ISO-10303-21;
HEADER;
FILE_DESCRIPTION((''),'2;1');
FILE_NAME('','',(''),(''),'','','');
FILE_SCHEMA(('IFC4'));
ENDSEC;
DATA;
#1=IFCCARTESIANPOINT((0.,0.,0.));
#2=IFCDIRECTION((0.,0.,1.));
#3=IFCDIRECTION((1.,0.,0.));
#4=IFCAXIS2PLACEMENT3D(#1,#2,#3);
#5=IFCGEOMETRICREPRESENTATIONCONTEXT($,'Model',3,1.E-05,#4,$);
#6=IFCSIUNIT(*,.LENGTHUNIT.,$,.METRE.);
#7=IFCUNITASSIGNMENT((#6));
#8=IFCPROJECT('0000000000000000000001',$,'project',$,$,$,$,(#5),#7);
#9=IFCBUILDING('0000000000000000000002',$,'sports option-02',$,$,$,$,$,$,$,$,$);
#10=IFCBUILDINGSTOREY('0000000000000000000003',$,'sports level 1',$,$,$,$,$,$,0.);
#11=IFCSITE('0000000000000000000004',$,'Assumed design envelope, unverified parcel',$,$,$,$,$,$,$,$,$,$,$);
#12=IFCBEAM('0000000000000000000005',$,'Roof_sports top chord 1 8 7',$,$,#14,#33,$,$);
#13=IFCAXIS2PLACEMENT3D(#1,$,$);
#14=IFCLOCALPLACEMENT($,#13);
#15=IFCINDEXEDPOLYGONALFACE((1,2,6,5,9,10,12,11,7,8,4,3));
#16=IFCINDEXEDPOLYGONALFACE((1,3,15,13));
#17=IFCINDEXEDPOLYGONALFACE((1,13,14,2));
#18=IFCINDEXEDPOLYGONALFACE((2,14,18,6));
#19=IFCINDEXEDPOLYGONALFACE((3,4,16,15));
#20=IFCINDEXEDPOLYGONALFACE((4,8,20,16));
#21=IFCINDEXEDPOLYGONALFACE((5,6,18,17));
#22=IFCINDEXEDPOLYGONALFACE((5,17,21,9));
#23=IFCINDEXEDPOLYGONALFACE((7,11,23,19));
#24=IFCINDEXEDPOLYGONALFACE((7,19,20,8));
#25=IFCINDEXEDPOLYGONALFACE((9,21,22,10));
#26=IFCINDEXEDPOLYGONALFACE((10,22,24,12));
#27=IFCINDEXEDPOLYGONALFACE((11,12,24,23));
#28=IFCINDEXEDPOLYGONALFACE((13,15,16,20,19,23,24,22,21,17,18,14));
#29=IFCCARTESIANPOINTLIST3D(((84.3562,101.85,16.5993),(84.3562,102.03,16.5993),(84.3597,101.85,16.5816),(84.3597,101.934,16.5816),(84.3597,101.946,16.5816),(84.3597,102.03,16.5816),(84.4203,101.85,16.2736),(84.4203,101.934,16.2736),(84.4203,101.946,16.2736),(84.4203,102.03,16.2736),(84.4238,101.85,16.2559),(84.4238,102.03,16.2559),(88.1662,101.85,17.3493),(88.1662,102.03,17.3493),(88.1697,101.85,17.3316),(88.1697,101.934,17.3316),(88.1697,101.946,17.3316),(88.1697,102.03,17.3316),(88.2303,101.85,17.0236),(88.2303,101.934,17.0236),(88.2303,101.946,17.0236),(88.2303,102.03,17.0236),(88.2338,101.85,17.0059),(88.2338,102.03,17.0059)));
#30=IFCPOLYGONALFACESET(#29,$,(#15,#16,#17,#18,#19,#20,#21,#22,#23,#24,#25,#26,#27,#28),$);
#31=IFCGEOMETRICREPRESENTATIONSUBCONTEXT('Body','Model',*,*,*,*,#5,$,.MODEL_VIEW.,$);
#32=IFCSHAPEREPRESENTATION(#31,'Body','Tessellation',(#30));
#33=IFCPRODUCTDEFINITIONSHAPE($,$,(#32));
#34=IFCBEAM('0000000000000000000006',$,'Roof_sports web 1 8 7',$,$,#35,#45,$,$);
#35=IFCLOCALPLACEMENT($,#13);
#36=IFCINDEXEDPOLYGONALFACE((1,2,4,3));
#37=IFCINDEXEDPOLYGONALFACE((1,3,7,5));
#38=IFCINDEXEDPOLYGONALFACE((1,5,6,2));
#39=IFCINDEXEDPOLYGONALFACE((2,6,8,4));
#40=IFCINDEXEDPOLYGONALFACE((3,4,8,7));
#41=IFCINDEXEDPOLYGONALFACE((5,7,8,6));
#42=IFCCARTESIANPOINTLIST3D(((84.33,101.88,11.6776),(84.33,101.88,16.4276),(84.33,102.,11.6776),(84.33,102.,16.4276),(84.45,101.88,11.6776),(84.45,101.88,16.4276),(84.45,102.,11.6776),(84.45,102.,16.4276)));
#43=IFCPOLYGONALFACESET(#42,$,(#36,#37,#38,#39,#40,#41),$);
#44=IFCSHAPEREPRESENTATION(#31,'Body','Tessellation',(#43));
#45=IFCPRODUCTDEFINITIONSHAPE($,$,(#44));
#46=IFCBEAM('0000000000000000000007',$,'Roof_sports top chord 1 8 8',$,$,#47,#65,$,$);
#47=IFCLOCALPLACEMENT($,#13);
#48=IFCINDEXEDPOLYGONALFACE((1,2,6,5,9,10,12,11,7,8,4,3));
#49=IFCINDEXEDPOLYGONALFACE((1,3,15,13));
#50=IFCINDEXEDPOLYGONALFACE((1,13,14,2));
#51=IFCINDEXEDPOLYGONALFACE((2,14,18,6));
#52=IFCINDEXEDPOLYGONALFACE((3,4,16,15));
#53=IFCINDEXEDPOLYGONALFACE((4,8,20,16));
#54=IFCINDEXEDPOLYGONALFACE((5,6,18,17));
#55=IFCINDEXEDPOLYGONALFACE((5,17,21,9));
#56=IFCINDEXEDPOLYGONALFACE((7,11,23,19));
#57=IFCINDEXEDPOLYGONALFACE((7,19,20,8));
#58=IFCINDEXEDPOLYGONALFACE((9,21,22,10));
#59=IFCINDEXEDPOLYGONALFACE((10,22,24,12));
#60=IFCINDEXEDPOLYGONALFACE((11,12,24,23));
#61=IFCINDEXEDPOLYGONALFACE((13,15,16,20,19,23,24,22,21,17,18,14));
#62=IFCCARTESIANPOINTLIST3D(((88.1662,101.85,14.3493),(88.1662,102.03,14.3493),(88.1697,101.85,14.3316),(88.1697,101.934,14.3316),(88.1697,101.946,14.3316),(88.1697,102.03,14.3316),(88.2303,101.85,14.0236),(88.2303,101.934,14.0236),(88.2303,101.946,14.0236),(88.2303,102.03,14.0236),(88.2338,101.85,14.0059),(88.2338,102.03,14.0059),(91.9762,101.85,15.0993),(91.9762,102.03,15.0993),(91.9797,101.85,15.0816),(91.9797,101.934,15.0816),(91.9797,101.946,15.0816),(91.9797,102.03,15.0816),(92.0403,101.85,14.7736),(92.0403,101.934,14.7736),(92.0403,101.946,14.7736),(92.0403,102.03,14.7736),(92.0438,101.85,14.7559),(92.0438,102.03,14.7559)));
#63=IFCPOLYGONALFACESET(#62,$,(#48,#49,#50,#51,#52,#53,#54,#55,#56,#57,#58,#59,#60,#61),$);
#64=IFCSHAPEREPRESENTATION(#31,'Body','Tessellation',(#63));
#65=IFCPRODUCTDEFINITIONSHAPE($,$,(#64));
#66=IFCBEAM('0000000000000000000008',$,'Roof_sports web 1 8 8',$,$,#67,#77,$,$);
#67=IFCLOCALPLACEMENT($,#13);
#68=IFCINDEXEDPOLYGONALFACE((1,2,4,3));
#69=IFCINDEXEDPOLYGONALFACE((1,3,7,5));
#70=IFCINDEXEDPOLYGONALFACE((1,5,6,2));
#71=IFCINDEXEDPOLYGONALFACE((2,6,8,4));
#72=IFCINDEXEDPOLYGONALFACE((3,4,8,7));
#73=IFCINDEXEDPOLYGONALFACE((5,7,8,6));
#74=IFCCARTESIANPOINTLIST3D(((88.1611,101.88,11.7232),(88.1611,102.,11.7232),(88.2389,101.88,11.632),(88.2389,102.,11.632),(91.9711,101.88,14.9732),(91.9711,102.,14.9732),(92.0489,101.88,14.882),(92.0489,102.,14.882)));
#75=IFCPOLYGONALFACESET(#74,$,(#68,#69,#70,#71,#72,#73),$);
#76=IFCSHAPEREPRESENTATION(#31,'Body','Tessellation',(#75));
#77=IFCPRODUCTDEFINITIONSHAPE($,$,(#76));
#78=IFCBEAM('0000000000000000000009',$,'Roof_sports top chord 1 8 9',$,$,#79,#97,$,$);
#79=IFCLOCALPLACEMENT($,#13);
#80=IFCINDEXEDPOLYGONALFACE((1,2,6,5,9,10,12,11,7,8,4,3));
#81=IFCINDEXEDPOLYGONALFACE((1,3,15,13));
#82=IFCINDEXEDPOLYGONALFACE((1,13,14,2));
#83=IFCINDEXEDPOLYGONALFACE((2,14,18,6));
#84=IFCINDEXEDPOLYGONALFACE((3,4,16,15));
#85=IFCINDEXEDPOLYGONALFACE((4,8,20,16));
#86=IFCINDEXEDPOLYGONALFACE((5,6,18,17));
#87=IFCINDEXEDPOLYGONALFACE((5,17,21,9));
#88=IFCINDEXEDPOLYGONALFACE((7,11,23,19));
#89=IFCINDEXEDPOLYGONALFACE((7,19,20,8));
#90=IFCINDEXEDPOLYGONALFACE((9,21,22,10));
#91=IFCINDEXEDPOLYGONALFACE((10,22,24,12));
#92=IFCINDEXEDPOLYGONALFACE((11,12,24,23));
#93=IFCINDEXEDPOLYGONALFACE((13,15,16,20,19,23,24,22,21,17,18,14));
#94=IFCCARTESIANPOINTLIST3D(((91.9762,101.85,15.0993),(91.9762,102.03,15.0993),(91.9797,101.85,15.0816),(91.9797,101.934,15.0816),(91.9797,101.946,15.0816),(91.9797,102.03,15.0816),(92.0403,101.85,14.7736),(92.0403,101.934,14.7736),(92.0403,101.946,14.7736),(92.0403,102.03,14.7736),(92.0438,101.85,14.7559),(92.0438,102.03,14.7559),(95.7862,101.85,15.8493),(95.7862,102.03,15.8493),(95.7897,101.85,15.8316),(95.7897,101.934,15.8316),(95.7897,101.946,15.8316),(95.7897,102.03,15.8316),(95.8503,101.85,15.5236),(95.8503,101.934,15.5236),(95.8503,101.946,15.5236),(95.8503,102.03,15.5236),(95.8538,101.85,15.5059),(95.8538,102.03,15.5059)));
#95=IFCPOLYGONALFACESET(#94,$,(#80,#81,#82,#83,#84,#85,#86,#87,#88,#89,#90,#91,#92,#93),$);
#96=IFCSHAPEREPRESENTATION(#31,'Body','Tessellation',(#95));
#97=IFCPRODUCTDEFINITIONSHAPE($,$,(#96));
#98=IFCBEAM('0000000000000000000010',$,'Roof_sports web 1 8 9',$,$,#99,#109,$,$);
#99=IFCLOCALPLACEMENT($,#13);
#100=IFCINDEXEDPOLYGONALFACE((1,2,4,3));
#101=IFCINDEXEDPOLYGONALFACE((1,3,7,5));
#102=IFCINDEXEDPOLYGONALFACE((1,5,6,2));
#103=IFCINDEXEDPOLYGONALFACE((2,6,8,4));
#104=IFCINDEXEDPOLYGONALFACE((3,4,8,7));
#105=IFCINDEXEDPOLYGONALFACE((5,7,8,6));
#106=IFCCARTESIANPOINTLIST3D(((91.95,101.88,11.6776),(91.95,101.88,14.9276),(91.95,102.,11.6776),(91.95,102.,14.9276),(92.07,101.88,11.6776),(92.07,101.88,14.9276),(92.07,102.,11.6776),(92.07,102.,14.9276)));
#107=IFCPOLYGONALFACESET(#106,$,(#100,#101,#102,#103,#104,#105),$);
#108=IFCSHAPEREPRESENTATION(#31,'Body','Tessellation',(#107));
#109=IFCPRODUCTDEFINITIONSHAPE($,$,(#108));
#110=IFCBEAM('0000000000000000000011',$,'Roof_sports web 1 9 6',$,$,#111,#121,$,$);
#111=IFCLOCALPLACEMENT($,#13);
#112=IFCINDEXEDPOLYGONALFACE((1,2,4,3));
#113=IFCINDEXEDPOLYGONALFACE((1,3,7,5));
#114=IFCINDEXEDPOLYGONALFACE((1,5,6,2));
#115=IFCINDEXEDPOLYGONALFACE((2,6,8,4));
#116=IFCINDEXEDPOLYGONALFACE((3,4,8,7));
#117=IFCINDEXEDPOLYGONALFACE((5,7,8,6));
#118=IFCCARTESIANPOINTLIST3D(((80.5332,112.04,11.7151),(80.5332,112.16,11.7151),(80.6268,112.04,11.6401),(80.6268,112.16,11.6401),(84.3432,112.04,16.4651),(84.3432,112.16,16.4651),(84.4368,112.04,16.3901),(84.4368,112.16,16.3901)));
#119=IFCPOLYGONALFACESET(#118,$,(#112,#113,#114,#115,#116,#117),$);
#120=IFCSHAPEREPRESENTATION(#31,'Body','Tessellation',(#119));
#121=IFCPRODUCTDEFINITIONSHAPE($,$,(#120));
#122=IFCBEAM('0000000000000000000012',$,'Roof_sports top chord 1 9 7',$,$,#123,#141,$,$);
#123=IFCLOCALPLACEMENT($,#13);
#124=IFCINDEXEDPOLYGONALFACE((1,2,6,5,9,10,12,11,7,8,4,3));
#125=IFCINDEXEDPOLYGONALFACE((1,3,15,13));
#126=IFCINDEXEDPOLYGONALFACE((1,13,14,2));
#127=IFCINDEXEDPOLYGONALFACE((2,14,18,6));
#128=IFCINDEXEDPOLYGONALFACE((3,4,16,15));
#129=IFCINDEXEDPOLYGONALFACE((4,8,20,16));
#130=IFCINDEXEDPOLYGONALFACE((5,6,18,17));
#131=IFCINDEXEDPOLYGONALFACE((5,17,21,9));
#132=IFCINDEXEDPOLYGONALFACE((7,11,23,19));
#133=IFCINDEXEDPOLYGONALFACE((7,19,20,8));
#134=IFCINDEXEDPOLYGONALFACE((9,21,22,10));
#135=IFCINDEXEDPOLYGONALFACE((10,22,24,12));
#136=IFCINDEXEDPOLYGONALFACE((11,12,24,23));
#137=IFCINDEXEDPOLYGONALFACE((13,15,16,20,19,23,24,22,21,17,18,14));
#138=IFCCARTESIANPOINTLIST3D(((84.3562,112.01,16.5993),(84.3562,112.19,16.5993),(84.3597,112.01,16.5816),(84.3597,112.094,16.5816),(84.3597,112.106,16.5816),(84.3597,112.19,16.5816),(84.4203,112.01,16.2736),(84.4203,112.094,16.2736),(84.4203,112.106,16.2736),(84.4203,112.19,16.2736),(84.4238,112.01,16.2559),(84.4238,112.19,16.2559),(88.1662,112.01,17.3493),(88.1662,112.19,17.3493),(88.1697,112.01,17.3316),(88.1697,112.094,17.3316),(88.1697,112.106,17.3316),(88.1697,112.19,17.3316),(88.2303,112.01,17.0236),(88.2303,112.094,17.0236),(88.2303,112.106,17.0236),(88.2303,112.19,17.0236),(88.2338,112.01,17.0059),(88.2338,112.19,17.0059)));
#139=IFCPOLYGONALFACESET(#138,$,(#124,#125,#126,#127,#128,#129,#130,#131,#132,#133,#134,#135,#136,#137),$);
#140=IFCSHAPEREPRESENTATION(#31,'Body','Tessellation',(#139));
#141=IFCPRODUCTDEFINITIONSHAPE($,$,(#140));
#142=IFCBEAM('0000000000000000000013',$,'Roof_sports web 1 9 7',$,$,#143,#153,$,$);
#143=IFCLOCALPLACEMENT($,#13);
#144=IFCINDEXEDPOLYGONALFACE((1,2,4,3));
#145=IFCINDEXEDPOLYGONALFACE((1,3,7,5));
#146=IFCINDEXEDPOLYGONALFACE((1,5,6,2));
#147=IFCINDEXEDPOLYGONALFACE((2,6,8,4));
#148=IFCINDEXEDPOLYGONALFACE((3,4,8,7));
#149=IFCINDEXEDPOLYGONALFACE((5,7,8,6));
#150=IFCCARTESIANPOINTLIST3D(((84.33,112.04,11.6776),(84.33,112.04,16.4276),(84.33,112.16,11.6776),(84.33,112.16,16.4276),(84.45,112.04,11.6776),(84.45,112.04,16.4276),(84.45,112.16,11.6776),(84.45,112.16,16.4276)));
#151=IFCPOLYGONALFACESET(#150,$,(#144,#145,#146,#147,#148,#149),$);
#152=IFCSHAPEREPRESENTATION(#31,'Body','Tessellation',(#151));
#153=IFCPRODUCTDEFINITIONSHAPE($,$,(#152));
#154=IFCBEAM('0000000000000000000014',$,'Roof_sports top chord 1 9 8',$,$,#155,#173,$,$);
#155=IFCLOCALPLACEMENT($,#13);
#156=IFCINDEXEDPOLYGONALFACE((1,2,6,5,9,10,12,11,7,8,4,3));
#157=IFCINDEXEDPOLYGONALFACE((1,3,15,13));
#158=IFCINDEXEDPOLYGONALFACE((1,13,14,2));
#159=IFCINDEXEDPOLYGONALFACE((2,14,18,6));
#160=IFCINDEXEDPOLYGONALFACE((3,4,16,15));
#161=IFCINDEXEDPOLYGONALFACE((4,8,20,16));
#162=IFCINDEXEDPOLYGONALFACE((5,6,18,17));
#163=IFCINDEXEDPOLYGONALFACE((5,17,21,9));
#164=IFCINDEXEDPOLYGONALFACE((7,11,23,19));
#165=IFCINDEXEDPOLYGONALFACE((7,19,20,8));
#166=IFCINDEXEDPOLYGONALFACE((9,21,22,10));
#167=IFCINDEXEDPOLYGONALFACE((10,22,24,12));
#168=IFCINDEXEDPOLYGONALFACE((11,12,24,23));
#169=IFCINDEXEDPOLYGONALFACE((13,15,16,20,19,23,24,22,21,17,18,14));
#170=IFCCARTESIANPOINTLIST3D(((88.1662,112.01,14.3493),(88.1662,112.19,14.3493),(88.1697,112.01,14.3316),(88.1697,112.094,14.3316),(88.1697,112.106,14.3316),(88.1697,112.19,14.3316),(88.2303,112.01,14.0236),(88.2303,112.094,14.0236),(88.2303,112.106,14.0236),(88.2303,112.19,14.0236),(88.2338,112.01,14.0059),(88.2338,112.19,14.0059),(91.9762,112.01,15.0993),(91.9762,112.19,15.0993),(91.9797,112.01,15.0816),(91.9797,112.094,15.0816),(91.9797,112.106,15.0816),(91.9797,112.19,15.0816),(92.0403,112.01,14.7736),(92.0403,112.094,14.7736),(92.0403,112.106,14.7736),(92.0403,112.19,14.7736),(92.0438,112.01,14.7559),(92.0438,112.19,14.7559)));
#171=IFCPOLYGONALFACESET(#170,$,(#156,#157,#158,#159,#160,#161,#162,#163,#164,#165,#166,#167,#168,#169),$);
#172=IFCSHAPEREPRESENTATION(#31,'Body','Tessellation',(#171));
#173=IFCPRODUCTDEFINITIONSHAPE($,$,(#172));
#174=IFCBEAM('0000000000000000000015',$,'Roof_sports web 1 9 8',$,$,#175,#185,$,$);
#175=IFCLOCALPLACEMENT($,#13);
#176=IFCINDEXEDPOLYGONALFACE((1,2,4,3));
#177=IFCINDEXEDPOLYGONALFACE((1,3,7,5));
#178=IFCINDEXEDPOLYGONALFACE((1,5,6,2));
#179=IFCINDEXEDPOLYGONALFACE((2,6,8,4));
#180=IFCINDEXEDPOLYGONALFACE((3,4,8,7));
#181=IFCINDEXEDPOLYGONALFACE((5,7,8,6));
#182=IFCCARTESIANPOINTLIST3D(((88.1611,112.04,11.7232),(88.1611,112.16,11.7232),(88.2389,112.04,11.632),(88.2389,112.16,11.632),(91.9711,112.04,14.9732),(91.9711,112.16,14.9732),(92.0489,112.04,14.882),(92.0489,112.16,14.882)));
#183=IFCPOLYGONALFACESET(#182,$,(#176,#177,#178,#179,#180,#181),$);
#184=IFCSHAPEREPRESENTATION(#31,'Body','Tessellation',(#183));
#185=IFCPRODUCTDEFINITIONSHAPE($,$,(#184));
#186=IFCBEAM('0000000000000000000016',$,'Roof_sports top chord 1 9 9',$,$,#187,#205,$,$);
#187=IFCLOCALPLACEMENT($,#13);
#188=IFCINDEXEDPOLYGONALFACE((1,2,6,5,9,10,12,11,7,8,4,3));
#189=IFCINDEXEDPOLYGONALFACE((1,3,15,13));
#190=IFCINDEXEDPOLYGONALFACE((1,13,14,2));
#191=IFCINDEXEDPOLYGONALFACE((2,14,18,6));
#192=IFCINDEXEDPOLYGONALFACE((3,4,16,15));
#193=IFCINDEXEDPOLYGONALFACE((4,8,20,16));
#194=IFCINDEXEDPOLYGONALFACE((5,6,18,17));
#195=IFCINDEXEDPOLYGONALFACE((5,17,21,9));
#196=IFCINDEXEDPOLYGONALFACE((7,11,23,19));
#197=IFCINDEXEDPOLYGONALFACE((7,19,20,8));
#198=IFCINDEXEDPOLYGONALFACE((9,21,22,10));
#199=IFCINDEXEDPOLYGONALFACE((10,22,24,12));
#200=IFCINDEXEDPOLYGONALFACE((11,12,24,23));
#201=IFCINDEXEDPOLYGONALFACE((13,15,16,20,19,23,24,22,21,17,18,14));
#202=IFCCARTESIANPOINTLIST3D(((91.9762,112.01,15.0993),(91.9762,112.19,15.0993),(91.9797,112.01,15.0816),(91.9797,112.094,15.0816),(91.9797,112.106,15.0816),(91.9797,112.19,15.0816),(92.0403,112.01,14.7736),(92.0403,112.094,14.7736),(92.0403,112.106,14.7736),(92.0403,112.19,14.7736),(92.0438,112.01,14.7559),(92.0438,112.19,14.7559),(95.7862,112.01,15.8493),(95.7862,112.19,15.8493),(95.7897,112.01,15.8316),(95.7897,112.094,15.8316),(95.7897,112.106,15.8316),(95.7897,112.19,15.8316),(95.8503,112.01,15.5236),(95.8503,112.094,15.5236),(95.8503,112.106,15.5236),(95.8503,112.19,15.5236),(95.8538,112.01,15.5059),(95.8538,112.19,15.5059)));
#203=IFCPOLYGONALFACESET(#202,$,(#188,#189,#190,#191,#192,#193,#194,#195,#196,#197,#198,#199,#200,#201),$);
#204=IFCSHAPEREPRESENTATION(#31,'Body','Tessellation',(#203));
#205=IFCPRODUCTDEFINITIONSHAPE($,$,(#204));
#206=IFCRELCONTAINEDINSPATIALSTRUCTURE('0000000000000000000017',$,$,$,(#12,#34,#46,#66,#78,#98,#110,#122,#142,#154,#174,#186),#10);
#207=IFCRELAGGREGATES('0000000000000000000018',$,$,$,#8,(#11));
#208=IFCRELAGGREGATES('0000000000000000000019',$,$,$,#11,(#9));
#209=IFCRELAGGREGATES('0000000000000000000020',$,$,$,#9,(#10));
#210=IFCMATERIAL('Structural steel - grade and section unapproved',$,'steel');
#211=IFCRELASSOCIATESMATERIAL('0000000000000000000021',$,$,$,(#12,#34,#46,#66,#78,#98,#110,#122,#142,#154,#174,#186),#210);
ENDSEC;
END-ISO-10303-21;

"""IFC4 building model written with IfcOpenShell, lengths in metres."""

from ifc_helpers import new_model, si_unit, frame, origin_with_axes, place, context, subcontext, project, spatial, rectangle, i_section, extrude, material, element, save


model = new_model("IFC4")

# Units and contexts
model_context = context("Model", 3, precision=1e-05, world=origin_with_axes())
body_context = subcontext(model_context, "Body", "Model", "MODEL_VIEW")
ifc_project = project(units=[si_unit("LENGTHUNIT", "METRE")], contexts=[model_context])

# Site, building, storey
site = spatial("IfcSite", under=ifc_project, Name="Assumed design envelope, unverified parcel")
building = spatial("IfcBuilding", under=site, Name="sports option-02")
storey = spatial("IfcBuildingStorey", under=building, Name="sports level 1", Elevation=0.0)

# Beams
ifc_material_1 = material(Name="Structural steel - grade and section unapproved", Category="steel")
beam_1_placement = place(None, frame((84.39, 101.94, 16.4276), z_axis=(0.98117, 0.0, 0.193144), x_axis=(0.0, 1.0, 0.0)))
element("IfcBeam", 1, at=beam_1_placement, inside=storey, material=ifc_material_1, Name="Roof_sports top chord 1 8 7", context=body_context, shape_type="SweptSolid", body=[
    extrude(i_section(OverallWidth=0.18, OverallDepth=0.35, WebThickness=0.012, FlangeThickness=0.018, FilletRadius=0.0), origin_with_axes(), (0.0, 0.0, 1.0), 3.8831),
])
beam_2_placement = place(None, frame((84.39, 101.94, 11.6776), z_axis=(0.0, 0.0, 1.0), x_axis=(-1.0, 0.0, 0.0)))
element("IfcBeam", 2, at=beam_2_placement, inside=storey, material=ifc_material_1, Name="Roof_sports web 1 8 7", context=body_context, shape_type="SweptSolid", body=[
    extrude(rectangle(XDim=0.12, YDim=0.12), origin_with_axes(), (0.0, 0.0, 1.0), 4.75),
])
beam_3_placement = place(None, frame((88.2, 101.94, 14.1776), z_axis=(0.981171, 0.0, 0.193143), x_axis=(0.0, 1.0, 0.0)))
element("IfcBeam", 3, at=beam_3_placement, inside=storey, material=ifc_material_1, Name="Roof_sports top chord 1 8 8", context=body_context, shape_type="SweptSolid", body=[
    extrude(i_section(OverallWidth=0.18, OverallDepth=0.35, WebThickness=0.012, FlangeThickness=0.018, FilletRadius=0.0), origin_with_axes(), (0.0, 0.0, 1.0), 3.8831),
])
beam_4_placement = place(None, frame((88.2, 101.94, 11.6776), z_axis=(0.760805, 0.0, 0.64898), x_axis=(0.0, 1.0, 0.0)))
element("IfcBeam", 4, at=beam_4_placement, inside=storey, material=ifc_material_1, Name="Roof_sports web 1 8 8", context=body_context, shape_type="SweptSolid", body=[
    extrude(rectangle(XDim=0.12, YDim=0.12), origin_with_axes(), (0.0, 0.0, 1.0), 5.0079),
])
beam_5_placement = place(None, frame((92.01, 101.94, 14.9276), z_axis=(0.98117, 0.0, 0.193144), x_axis=(0.0, 1.0, 0.0)))
element("IfcBeam", 5, at=beam_5_placement, inside=storey, material=ifc_material_1, Name="Roof_sports top chord 1 8 9", context=body_context, shape_type="SweptSolid", body=[
    extrude(i_section(OverallWidth=0.18, OverallDepth=0.35, WebThickness=0.012, FlangeThickness=0.018, FilletRadius=0.0), origin_with_axes(), (0.0, 0.0, 1.0), 3.8831),
])
beam_6_placement = place(None, frame((92.01, 101.94, 11.6776), z_axis=(0.0, 0.0, 1.0), x_axis=(-1.0, 0.0, 0.0)))
element("IfcBeam", 6, at=beam_6_placement, inside=storey, material=ifc_material_1, Name="Roof_sports web 1 8 9", context=body_context, shape_type="SweptSolid", body=[
    extrude(rectangle(XDim=0.12, YDim=0.12), origin_with_axes(), (0.0, 0.0, 1.0), 3.25),
])
beam_7_placement = place(None, frame((80.58, 112.1, 11.6776), z_axis=(0.625696, 0.0, 0.780067), x_axis=(0.0, 1.0, 0.0)))
element("IfcBeam", 7, at=beam_7_placement, inside=storey, material=ifc_material_1, Name="Roof_sports web 1 9 6", context=body_context, shape_type="SweptSolid", body=[
    extrude(rectangle(XDim=0.12, YDim=0.12), origin_with_axes(), (0.0, 0.0, 1.0), 6.0892),
])
beam_8_placement = place(None, frame((84.39, 112.1, 16.4276), z_axis=(0.98117, 0.0, 0.193144), x_axis=(0.0, 1.0, 0.0)))
element("IfcBeam", 8, at=beam_8_placement, inside=storey, material=ifc_material_1, Name="Roof_sports top chord 1 9 7", context=body_context, shape_type="SweptSolid", body=[
    extrude(i_section(OverallWidth=0.18, OverallDepth=0.35, WebThickness=0.012, FlangeThickness=0.018, FilletRadius=0.0), origin_with_axes(), (0.0, 0.0, 1.0), 3.8831),
])
beam_9_placement = place(None, frame((84.39, 112.1, 11.6776), z_axis=(0.0, 0.0, 1.0), x_axis=(-1.0, 0.0, 0.0)))
element("IfcBeam", 9, at=beam_9_placement, inside=storey, material=ifc_material_1, Name="Roof_sports web 1 9 7", context=body_context, shape_type="SweptSolid", body=[
    extrude(rectangle(XDim=0.12, YDim=0.12), origin_with_axes(), (0.0, 0.0, 1.0), 4.75),
])
beam_10_placement = place(None, frame((88.2, 112.1, 14.1776), z_axis=(0.981171, 0.0, 0.193143), x_axis=(0.0, 1.0, 0.0)))
element("IfcBeam", 10, at=beam_10_placement, inside=storey, material=ifc_material_1, Name="Roof_sports top chord 1 9 8", context=body_context, shape_type="SweptSolid", body=[
    extrude(i_section(OverallWidth=0.18, OverallDepth=0.35, WebThickness=0.012, FlangeThickness=0.018, FilletRadius=0.0), origin_with_axes(), (0.0, 0.0, 1.0), 3.8831),
])
beam_11_placement = place(None, frame((88.2, 112.1, 11.6776), z_axis=(0.760805, 0.0, 0.64898), x_axis=(0.0, 1.0, 0.0)))
element("IfcBeam", 11, at=beam_11_placement, inside=storey, material=ifc_material_1, Name="Roof_sports web 1 9 8", context=body_context, shape_type="SweptSolid", body=[
    extrude(rectangle(XDim=0.12, YDim=0.12), origin_with_axes(), (0.0, 0.0, 1.0), 5.0079),
])
beam_12_placement = place(None, frame((92.01, 112.1, 14.9276), z_axis=(0.98117, 0.0, 0.193144), x_axis=(0.0, 1.0, 0.0)))
element("IfcBeam", 12, at=beam_12_placement, inside=storey, material=ifc_material_1, Name="Roof_sports top chord 1 9 9", context=body_context, shape_type="SweptSolid", body=[
    extrude(i_section(OverallWidth=0.18, OverallDepth=0.35, WebThickness=0.012, FlangeThickness=0.018, FilletRadius=0.0), origin_with_axes(), (0.0, 0.0, 1.0), 3.8831),
])

save(model, "model.ifc")
